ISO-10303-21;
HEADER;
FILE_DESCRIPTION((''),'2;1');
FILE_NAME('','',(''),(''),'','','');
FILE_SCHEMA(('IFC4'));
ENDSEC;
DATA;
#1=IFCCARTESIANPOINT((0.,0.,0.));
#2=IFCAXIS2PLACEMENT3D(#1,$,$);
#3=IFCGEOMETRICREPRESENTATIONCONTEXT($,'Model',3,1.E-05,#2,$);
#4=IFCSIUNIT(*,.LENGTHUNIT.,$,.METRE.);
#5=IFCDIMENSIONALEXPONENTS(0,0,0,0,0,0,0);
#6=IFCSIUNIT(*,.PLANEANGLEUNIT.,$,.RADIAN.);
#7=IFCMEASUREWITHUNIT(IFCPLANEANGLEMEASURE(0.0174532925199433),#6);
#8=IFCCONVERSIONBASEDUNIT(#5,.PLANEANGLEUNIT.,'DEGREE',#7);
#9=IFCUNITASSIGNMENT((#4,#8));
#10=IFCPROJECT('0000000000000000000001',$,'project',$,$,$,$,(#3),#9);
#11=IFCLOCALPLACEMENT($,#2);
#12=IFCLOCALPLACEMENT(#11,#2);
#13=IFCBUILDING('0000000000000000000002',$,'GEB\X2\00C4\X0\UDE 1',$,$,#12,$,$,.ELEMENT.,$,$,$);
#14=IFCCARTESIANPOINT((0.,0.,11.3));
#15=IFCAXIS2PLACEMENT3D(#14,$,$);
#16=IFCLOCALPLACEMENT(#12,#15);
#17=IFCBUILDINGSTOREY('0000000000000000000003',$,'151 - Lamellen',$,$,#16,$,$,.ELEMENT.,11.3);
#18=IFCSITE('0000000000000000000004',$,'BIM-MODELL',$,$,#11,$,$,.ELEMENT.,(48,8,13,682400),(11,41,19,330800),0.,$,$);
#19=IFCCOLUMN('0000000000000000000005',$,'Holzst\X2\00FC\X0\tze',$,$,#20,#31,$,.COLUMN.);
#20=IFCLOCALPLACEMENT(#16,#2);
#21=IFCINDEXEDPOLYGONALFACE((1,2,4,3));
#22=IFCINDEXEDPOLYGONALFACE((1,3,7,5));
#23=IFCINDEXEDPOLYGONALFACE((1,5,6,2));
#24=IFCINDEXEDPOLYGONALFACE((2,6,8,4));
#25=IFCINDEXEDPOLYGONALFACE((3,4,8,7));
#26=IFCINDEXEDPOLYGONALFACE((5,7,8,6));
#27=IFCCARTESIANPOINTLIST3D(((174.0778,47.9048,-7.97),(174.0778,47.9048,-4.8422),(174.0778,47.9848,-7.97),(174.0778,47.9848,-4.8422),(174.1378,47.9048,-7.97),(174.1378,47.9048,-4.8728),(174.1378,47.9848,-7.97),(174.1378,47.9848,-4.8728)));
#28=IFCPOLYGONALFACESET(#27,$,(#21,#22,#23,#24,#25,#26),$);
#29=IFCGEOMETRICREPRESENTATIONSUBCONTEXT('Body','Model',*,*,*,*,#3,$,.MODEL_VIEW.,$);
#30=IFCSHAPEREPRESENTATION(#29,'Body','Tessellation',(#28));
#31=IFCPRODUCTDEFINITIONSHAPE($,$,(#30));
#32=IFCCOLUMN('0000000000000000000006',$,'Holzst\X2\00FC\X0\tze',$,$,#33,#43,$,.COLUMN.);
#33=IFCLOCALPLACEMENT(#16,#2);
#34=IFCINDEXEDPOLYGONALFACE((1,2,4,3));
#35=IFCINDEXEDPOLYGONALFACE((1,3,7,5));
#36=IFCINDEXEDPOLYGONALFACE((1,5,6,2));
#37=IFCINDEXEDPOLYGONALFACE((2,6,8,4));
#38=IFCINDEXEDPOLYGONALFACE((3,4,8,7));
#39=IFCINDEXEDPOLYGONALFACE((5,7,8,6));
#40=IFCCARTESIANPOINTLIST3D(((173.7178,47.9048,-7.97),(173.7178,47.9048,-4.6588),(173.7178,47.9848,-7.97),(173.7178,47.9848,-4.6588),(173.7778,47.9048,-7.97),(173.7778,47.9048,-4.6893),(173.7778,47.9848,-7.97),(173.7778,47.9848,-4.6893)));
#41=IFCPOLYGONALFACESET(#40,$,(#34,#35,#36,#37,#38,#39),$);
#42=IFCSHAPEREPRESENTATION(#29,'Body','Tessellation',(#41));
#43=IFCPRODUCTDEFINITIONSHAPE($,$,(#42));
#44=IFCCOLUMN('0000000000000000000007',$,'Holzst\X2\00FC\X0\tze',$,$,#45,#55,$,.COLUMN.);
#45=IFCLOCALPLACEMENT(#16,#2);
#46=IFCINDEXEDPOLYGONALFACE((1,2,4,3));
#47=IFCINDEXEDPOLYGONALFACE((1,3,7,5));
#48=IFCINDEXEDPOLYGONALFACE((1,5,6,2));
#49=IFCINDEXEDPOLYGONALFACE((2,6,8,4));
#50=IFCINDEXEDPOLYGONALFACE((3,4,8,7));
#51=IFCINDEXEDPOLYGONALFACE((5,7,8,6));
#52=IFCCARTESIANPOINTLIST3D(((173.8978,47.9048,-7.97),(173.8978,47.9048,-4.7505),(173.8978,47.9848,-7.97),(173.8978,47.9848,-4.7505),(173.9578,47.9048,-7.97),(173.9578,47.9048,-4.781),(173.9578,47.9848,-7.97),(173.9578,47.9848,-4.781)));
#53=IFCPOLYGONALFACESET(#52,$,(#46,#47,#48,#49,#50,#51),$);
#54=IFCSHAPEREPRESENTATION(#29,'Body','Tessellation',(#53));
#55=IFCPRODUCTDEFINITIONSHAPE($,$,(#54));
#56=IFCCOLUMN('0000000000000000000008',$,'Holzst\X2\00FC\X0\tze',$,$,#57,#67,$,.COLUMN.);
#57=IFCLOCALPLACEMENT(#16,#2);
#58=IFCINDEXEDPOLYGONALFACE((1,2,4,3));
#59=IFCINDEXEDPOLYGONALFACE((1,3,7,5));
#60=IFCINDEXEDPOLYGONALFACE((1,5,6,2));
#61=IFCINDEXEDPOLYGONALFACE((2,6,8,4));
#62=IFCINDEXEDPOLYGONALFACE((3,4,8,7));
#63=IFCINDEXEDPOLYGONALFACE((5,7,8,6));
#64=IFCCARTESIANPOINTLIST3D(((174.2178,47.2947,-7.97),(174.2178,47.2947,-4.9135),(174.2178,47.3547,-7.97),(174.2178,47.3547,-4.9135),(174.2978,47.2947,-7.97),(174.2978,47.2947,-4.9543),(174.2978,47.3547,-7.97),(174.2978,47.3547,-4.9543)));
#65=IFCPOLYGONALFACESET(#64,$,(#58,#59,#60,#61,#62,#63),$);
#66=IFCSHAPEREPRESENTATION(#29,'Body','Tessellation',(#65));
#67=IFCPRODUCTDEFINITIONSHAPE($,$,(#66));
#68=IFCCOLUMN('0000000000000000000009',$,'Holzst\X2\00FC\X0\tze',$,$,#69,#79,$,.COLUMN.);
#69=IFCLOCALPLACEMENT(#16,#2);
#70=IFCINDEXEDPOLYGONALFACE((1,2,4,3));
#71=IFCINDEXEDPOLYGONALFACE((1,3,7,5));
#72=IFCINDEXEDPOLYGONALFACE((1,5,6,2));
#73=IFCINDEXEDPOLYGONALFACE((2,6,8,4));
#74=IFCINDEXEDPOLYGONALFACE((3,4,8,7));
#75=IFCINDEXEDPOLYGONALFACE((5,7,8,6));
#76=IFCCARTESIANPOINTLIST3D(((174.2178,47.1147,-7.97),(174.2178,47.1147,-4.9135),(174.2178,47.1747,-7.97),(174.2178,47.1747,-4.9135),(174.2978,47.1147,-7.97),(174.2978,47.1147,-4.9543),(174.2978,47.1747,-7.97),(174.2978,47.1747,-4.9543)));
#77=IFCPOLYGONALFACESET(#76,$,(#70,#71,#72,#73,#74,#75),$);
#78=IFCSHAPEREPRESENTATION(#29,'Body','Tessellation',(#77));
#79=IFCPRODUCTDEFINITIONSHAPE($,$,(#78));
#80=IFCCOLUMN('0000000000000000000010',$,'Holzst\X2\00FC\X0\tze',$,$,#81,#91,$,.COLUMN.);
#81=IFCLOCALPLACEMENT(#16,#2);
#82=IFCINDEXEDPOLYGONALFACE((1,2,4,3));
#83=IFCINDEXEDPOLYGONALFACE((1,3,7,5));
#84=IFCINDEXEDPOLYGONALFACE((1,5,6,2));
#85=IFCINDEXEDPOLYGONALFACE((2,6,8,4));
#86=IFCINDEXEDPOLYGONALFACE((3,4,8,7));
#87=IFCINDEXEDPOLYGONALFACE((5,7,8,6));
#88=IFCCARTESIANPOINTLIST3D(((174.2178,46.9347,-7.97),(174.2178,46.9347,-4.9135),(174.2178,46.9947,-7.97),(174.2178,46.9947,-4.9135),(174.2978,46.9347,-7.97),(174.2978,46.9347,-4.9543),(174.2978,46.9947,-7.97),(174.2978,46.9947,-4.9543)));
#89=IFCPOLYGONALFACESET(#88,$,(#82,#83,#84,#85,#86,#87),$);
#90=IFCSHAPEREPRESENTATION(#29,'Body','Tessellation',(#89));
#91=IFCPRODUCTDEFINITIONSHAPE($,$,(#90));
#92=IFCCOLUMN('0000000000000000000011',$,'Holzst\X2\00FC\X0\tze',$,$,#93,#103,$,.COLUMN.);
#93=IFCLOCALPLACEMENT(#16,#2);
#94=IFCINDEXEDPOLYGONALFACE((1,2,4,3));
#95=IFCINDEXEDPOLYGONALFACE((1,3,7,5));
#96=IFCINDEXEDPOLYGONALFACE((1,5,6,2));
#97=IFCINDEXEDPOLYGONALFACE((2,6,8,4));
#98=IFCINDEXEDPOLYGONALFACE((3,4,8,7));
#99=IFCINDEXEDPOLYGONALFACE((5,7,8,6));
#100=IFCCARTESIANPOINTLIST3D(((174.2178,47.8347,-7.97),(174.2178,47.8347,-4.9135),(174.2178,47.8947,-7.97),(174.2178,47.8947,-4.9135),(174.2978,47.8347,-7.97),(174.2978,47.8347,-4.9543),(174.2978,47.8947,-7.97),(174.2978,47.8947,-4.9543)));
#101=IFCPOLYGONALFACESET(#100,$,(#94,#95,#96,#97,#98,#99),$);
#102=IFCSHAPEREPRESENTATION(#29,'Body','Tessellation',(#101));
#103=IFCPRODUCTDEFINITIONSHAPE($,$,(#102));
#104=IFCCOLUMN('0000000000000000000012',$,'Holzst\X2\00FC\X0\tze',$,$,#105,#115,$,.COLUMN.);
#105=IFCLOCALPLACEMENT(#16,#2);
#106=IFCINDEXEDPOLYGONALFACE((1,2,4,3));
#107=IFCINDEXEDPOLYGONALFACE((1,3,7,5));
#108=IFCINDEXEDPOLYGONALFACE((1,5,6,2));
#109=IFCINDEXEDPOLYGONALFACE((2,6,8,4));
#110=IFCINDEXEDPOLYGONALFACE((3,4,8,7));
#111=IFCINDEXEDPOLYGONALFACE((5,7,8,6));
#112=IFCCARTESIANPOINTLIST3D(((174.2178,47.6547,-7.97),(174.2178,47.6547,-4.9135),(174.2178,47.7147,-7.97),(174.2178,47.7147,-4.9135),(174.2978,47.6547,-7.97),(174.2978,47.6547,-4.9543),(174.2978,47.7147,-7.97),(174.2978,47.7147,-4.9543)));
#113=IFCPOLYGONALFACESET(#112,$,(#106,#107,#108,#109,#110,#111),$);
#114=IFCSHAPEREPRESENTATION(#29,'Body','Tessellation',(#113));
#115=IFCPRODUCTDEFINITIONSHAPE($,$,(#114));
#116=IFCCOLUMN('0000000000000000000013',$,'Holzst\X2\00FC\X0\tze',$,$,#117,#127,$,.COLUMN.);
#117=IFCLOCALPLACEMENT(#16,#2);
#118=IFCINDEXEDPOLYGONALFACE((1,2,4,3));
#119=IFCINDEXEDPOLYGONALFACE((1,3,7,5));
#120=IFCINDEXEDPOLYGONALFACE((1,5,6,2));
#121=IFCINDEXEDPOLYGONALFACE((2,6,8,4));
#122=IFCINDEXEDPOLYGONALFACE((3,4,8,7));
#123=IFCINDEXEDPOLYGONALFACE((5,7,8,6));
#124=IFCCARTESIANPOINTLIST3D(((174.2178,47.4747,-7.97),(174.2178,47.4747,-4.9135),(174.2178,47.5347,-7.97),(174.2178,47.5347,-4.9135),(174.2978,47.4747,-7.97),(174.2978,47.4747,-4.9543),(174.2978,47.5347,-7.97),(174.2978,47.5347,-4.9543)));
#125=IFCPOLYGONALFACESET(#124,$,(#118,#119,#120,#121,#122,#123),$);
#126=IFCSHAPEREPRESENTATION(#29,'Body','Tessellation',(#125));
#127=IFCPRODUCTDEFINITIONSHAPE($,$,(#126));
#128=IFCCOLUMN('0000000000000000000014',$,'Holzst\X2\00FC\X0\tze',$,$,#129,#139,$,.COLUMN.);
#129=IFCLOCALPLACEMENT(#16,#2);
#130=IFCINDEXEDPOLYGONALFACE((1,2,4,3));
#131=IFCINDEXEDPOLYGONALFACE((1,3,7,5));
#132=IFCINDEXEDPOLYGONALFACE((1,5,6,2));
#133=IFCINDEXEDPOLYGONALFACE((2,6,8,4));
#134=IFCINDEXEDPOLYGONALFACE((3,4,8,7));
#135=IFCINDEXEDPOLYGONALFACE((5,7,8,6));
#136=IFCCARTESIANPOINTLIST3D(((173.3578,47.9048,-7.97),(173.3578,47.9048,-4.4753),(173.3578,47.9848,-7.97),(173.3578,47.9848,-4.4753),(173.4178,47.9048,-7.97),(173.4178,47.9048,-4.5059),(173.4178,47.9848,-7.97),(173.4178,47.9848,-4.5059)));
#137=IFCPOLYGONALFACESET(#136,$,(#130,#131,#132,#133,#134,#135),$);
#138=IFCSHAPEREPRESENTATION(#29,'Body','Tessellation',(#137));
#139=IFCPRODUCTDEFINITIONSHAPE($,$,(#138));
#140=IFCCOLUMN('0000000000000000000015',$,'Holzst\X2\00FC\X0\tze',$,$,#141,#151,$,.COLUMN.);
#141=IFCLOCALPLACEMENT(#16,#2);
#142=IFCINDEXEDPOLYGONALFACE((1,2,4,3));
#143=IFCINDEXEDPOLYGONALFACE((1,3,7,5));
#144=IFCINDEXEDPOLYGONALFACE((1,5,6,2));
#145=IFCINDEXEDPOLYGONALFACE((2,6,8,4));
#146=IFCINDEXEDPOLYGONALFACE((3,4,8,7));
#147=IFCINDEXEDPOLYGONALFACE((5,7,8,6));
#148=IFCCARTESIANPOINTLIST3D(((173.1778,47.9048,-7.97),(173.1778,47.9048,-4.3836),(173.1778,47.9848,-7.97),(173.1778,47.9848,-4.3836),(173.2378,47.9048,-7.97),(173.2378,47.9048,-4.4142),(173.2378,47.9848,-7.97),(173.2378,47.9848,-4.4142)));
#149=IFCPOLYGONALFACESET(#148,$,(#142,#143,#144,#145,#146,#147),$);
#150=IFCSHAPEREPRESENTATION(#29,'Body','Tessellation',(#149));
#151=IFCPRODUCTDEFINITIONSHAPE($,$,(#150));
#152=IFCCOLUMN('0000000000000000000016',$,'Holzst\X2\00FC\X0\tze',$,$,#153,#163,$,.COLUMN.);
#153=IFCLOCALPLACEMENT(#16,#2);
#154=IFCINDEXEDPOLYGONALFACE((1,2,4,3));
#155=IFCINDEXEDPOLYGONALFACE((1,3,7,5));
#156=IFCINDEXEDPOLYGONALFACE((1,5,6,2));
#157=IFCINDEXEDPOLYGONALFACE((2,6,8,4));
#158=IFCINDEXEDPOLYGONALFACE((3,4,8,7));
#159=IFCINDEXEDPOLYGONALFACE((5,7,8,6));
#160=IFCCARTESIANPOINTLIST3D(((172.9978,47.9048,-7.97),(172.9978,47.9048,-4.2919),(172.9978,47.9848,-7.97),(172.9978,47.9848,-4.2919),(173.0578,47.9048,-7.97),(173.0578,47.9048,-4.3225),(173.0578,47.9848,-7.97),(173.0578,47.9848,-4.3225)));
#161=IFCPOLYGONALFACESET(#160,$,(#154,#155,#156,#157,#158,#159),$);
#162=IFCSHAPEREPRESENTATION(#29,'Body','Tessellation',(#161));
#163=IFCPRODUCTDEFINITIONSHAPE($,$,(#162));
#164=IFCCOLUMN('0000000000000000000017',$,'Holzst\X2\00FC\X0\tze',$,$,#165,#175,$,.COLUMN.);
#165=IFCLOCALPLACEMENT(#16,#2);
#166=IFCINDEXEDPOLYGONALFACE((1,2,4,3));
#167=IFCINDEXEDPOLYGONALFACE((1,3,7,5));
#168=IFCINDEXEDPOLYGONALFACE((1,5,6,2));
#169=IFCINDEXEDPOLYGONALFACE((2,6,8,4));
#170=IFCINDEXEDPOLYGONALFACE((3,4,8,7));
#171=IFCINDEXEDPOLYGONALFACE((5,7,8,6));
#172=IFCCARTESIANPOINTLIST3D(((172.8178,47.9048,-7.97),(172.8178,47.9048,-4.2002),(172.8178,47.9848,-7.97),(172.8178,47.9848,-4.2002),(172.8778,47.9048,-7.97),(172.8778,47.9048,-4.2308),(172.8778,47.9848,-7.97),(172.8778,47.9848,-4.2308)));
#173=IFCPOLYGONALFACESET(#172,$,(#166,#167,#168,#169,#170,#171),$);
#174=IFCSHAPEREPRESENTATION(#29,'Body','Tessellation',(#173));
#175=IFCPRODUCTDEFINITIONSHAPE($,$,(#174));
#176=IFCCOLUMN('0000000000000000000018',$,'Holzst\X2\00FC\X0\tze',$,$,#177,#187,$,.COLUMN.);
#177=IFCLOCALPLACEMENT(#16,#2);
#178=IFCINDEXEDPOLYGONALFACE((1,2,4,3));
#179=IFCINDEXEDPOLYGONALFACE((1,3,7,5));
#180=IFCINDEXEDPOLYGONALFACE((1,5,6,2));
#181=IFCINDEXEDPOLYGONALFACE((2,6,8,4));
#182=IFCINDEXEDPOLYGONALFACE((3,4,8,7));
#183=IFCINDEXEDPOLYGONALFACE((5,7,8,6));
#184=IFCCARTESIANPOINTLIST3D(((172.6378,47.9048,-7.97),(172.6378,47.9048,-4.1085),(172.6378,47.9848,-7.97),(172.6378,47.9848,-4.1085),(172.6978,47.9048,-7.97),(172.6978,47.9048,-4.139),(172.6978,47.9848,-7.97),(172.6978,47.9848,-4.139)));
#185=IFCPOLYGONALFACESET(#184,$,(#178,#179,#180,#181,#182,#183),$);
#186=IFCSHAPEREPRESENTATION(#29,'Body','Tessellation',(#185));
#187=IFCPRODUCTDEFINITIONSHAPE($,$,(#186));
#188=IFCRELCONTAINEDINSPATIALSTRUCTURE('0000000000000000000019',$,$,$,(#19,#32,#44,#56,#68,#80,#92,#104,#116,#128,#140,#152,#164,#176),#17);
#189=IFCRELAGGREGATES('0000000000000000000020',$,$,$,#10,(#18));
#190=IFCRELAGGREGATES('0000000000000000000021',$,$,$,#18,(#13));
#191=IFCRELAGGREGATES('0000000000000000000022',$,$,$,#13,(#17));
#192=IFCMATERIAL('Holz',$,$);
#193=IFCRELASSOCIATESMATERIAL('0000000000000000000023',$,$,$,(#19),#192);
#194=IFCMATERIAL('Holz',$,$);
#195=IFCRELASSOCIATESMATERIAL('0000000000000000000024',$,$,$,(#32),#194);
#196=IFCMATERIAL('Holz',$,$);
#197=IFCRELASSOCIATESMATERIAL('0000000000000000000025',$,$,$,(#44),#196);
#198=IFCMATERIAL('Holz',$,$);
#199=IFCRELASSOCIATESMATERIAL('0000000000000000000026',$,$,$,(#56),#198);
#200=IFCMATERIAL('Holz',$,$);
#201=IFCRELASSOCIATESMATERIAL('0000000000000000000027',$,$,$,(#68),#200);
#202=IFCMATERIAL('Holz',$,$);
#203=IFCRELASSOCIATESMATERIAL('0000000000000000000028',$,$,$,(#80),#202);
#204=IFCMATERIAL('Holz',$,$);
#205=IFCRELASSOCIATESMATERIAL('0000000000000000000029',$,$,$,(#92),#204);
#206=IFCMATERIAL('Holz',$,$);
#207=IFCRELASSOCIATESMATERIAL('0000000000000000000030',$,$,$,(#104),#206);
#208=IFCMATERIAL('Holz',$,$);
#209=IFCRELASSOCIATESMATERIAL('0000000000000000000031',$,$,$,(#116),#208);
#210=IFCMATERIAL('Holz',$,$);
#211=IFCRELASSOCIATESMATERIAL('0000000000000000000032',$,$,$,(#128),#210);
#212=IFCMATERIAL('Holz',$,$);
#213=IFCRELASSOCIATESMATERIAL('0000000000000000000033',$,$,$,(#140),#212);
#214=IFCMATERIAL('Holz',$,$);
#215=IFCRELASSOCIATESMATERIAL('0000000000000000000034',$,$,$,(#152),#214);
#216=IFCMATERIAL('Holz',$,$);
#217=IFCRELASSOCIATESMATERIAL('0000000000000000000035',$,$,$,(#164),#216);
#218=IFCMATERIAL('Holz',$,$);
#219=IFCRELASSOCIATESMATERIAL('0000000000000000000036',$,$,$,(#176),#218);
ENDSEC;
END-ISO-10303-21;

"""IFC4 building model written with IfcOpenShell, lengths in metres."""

from ifc_helpers import new_model, entity, si_unit, converted_unit, frame, frame_2d, origin, origin_with_axes, place, context, subcontext, project, spatial, rectangle, extrude, clip, halfspace, material, element, save


model = new_model("IFC4")

# Units and contexts
model_context = context("Model", 3, precision=1e-05, world=origin())
body_context = subcontext(model_context, "Body", "Model", "MODEL_VIEW")
ifc_project = project(units=[si_unit("LENGTHUNIT", "METRE"), converted_unit("PLANEANGLEUNIT", "DEGREE", entity("IfcPlaneAngleMeasure", 0.0174532925199433), si_unit("PLANEANGLEUNIT", "RADIAN"), dimensions=[0, 0, 0, 0, 0, 0, 0])], contexts=[model_context])

# Site, building, storey
site_placement = place(None, origin())
site = spatial("IfcSite", under=ifc_project, at=site_placement, Name="BIM-MODELL", CompositionType="ELEMENT", RefLatitude=(48, 8, 13, 682400), RefLongitude=(11, 41, 19, 330800), RefElevation=0.0)
building_placement = place(site_placement, origin())
building = spatial("IfcBuilding", under=site, at=building_placement, Name="GEBÄUDE 1", CompositionType="ELEMENT")
storey_placement = place(building_placement, frame((0.0, 0.0, 11.3)))
storey = spatial("IfcBuildingStorey", under=building, at=storey_placement, Name="151 - Lamellen", CompositionType="ELEMENT", Elevation=11.3)

# Columns
ifc_material_1 = material(Name="Holz")
column_1_placement = place(storey_placement, frame((174.0778, 47.9048, -7.97)))
element("IfcColumn", 1, at=column_1_placement, inside=storey, material=ifc_material_1, Name="Holzstütze", PredefinedType="COLUMN", context=body_context, shape_type="Clipping", body=[
    clip(extrude(rectangle(XDim=0.06, YDim=0.08, at=frame_2d((0.03, 0.04), x_axis=(1.0, 0.0))), origin_with_axes(), (0.0, 0.0, 1.0), 3.1278), halfspace(frame((0.03, 0.04, 3.1125), z_axis=(-0.45399, 0.0, -0.891007), x_axis=(0.0, 1.0, 0.0)), True)),
])
ifc_material_2 = material(Name="Holz")
column_2_placement = place(storey_placement, frame((173.7178, 47.9048, -7.97)))
element("IfcColumn", 2, at=column_2_placement, inside=storey, material=ifc_material_2, Name="Holzstütze", PredefinedType="COLUMN", context=body_context, shape_type="Clipping", body=[
    clip(extrude(rectangle(XDim=0.06, YDim=0.08, at=frame_2d((0.03, 0.04), x_axis=(1.0, 0.0))), origin_with_axes(), (0.0, 0.0, 1.0), 3.3112), halfspace(frame((0.03, 0.04, 3.296), z_axis=(-0.45399, 0.0, -0.891007), x_axis=(0.0, 1.0, 0.0)), True)),
])
ifc_material_3 = material(Name="Holz")
column_3_placement = place(storey_placement, frame((173.8978, 47.9048, -7.97)))
element("IfcColumn", 3, at=column_3_placement, inside=storey, material=ifc_material_3, Name="Holzstütze", PredefinedType="COLUMN", context=body_context, shape_type="Clipping", body=[
    clip(extrude(rectangle(XDim=0.06, YDim=0.08, at=frame_2d((0.03, 0.04), x_axis=(1.0, 0.0))), origin_with_axes(), (0.0, 0.0, 1.0), 3.2195), halfspace(frame((0.03, 0.04, 3.2042), z_axis=(-0.45399, 0.0, -0.891007), x_axis=(0.0, 1.0, 0.0)), True)),
])
ifc_material_4 = material(Name="Holz")
column_4_placement = place(storey_placement, frame((174.2978, 47.2947, -7.97)))
element("IfcColumn", 4, at=column_4_placement, inside=storey, material=ifc_material_4, Name="Holzstütze", PredefinedType="COLUMN", context=body_context, shape_type="Clipping", body=[
    clip(extrude(rectangle(XDim=0.06, YDim=0.08, at=frame_2d((-0.04, 0.03), x_axis=(0.0, 1.0))), origin_with_axes(), (0.0, 0.0, 1.0), 3.0565), halfspace(frame((-0.04, 0.03, 3.0361), z_axis=(-0.45399, 0.0, -0.891007), x_axis=(0.891007, 0.0, -0.45399)), True)),
])
ifc_material_5 = material(Name="Holz")
column_5_placement = place(storey_placement, frame((174.2978, 47.1147, -7.97)))
element("IfcColumn", 5, at=column_5_placement, inside=storey, material=ifc_material_5, Name="Holzstütze", PredefinedType="COLUMN", context=body_context, shape_type="Clipping", body=[
    clip(extrude(rectangle(XDim=0.06, YDim=0.08, at=frame_2d((-0.04, 0.03), x_axis=(0.0, 1.0))), origin_with_axes(), (0.0, 0.0, 1.0), 3.0565), halfspace(frame((-0.04, 0.03, 3.0361), z_axis=(-0.45399, 0.0, -0.891007), x_axis=(0.891007, 0.0, -0.45399)), True)),
])
ifc_material_6 = material(Name="Holz")
column_6_placement = place(storey_placement, frame((174.2978, 46.9347, -7.97)))
element("IfcColumn", 6, at=column_6_placement, inside=storey, material=ifc_material_6, Name="Holzstütze", PredefinedType="COLUMN", context=body_context, shape_type="Clipping", body=[
    clip(extrude(rectangle(XDim=0.06, YDim=0.08, at=frame_2d((-0.04, 0.03), x_axis=(0.0, 1.0))), origin_with_axes(), (0.0, 0.0, 1.0), 3.0565), halfspace(frame((-0.04, 0.03, 3.0361), z_axis=(-0.45399, 0.0, -0.891007), x_axis=(0.891007, 0.0, -0.45399)), True)),
])
ifc_material_7 = material(Name="Holz")
column_7_placement = place(storey_placement, frame((174.2978, 47.8347, -7.97)))
element("IfcColumn", 7, at=column_7_placement, inside=storey, material=ifc_material_7, Name="Holzstütze", PredefinedType="COLUMN", context=body_context, shape_type="Clipping", body=[
    clip(extrude(rectangle(XDim=0.06, YDim=0.08, at=frame_2d((-0.04, 0.03), x_axis=(0.0, 1.0))), origin_with_axes(), (0.0, 0.0, 1.0), 3.0565), halfspace(frame((-0.04, 0.03, 3.0361), z_axis=(-0.45399, 0.0, -0.891007), x_axis=(0.891007, 0.0, -0.45399)), True)),
])
ifc_material_8 = material(Name="Holz")
column_8_placement = place(storey_placement, frame((174.2978, 47.6547, -7.97)))
element("IfcColumn", 8, at=column_8_placement, inside=storey, material=ifc_material_8, Name="Holzstütze", PredefinedType="COLUMN", context=body_context, shape_type="Clipping", body=[
    clip(extrude(rectangle(XDim=0.06, YDim=0.08, at=frame_2d((-0.04, 0.03), x_axis=(0.0, 1.0))), origin_with_axes(), (0.0, 0.0, 1.0), 3.0565), halfspace(frame((-0.04, 0.03, 3.0361), z_axis=(-0.45399, 0.0, -0.891007), x_axis=(0.891007, 0.0, -0.45399)), True)),
])
ifc_material_9 = material(Name="Holz")
column_9_placement = place(storey_placement, frame((174.2978, 47.4747, -7.97)))
element("IfcColumn", 9, at=column_9_placement, inside=storey, material=ifc_material_9, Name="Holzstütze", PredefinedType="COLUMN", context=body_context, shape_type="Clipping", body=[
    clip(extrude(rectangle(XDim=0.06, YDim=0.08, at=frame_2d((-0.04, 0.03), x_axis=(0.0, 1.0))), origin_with_axes(), (0.0, 0.0, 1.0), 3.0565), halfspace(frame((-0.04, 0.03, 3.0361), z_axis=(-0.45399, 0.0, -0.891007), x_axis=(0.891007, 0.0, -0.45399)), True)),
])
ifc_material_10 = material(Name="Holz")
column_10_placement = place(storey_placement, frame((173.3578, 47.9048, -7.97)))
element("IfcColumn", 10, at=column_10_placement, inside=storey, material=ifc_material_10, Name="Holzstütze", PredefinedType="COLUMN", context=body_context, shape_type="Clipping", body=[
    clip(extrude(rectangle(XDim=0.06, YDim=0.08, at=frame_2d((0.03, 0.04), x_axis=(1.0, 0.0))), origin_with_axes(), (0.0, 0.0, 1.0), 3.4947), halfspace(frame((0.03, 0.04, 3.4794), z_axis=(-0.45399, 0.0, -0.891007), x_axis=(0.0, 1.0, 0.0)), True)),
])
ifc_material_11 = material(Name="Holz")
column_11_placement = place(storey_placement, frame((173.1778, 47.9048, -7.97)))
element("IfcColumn", 11, at=column_11_placement, inside=storey, material=ifc_material_11, Name="Holzstütze", PredefinedType="COLUMN", context=body_context, shape_type="Clipping", body=[
    clip(extrude(rectangle(XDim=0.06, YDim=0.08, at=frame_2d((0.03, 0.04), x_axis=(1.0, 0.0))), origin_with_axes(), (0.0, 0.0, 1.0), 3.5864), halfspace(frame((0.03, 0.04, 3.5711), z_axis=(-0.45399, 0.0, -0.891007), x_axis=(0.0, 1.0, 0.0)), True)),
])
ifc_material_12 = material(Name="Holz")
column_12_placement = place(storey_placement, frame((172.9978, 47.9048, -7.97)))
element("IfcColumn", 12, at=column_12_placement, inside=storey, material=ifc_material_12, Name="Holzstütze", PredefinedType="COLUMN", context=body_context, shape_type="Clipping", body=[
    clip(extrude(rectangle(XDim=0.06, YDim=0.08, at=frame_2d((0.03, 0.04), x_axis=(1.0, 0.0))), origin_with_axes(), (0.0, 0.0, 1.0), 3.6781), halfspace(frame((0.03, 0.04, 3.6628), z_axis=(-0.45399, 0.0, -0.891007), x_axis=(0.0, 1.0, 0.0)), True)),
])
ifc_material_13 = material(Name="Holz")
column_13_placement = place(storey_placement, frame((172.8178, 47.9048, -7.97)))
element("IfcColumn", 13, at=column_13_placement, inside=storey, material=ifc_material_13, Name="Holzstütze", PredefinedType="COLUMN", context=body_context, shape_type="Clipping", body=[
    clip(extrude(rectangle(XDim=0.06, YDim=0.08, at=frame_2d((0.03, 0.04), x_axis=(1.0, 0.0))), origin_with_axes(), (0.0, 0.0, 1.0), 3.7698), halfspace(frame((0.03, 0.04, 3.7545), z_axis=(-0.45399, 0.0, -0.891007), x_axis=(0.0, 1.0, 0.0)), True)),
])
ifc_material_14 = material(Name="Holz")
column_14_placement = place(storey_placement, frame((172.6378, 47.9048, -7.97)))
element("IfcColumn", 14, at=column_14_placement, inside=storey, material=ifc_material_14, Name="Holzstütze", PredefinedType="COLUMN", context=body_context, shape_type="Clipping", body=[
    clip(extrude(rectangle(XDim=0.06, YDim=0.08, at=frame_2d((0.03, 0.04), x_axis=(1.0, 0.0))), origin_with_axes(), (0.0, 0.0, 1.0), 3.8615), halfspace(frame((0.03, 0.04, 3.8462), z_axis=(-0.45399, 0.0, -0.891007), x_axis=(0.0, 1.0, 0.0)), True)),
])

save(model, "model.ifc")
